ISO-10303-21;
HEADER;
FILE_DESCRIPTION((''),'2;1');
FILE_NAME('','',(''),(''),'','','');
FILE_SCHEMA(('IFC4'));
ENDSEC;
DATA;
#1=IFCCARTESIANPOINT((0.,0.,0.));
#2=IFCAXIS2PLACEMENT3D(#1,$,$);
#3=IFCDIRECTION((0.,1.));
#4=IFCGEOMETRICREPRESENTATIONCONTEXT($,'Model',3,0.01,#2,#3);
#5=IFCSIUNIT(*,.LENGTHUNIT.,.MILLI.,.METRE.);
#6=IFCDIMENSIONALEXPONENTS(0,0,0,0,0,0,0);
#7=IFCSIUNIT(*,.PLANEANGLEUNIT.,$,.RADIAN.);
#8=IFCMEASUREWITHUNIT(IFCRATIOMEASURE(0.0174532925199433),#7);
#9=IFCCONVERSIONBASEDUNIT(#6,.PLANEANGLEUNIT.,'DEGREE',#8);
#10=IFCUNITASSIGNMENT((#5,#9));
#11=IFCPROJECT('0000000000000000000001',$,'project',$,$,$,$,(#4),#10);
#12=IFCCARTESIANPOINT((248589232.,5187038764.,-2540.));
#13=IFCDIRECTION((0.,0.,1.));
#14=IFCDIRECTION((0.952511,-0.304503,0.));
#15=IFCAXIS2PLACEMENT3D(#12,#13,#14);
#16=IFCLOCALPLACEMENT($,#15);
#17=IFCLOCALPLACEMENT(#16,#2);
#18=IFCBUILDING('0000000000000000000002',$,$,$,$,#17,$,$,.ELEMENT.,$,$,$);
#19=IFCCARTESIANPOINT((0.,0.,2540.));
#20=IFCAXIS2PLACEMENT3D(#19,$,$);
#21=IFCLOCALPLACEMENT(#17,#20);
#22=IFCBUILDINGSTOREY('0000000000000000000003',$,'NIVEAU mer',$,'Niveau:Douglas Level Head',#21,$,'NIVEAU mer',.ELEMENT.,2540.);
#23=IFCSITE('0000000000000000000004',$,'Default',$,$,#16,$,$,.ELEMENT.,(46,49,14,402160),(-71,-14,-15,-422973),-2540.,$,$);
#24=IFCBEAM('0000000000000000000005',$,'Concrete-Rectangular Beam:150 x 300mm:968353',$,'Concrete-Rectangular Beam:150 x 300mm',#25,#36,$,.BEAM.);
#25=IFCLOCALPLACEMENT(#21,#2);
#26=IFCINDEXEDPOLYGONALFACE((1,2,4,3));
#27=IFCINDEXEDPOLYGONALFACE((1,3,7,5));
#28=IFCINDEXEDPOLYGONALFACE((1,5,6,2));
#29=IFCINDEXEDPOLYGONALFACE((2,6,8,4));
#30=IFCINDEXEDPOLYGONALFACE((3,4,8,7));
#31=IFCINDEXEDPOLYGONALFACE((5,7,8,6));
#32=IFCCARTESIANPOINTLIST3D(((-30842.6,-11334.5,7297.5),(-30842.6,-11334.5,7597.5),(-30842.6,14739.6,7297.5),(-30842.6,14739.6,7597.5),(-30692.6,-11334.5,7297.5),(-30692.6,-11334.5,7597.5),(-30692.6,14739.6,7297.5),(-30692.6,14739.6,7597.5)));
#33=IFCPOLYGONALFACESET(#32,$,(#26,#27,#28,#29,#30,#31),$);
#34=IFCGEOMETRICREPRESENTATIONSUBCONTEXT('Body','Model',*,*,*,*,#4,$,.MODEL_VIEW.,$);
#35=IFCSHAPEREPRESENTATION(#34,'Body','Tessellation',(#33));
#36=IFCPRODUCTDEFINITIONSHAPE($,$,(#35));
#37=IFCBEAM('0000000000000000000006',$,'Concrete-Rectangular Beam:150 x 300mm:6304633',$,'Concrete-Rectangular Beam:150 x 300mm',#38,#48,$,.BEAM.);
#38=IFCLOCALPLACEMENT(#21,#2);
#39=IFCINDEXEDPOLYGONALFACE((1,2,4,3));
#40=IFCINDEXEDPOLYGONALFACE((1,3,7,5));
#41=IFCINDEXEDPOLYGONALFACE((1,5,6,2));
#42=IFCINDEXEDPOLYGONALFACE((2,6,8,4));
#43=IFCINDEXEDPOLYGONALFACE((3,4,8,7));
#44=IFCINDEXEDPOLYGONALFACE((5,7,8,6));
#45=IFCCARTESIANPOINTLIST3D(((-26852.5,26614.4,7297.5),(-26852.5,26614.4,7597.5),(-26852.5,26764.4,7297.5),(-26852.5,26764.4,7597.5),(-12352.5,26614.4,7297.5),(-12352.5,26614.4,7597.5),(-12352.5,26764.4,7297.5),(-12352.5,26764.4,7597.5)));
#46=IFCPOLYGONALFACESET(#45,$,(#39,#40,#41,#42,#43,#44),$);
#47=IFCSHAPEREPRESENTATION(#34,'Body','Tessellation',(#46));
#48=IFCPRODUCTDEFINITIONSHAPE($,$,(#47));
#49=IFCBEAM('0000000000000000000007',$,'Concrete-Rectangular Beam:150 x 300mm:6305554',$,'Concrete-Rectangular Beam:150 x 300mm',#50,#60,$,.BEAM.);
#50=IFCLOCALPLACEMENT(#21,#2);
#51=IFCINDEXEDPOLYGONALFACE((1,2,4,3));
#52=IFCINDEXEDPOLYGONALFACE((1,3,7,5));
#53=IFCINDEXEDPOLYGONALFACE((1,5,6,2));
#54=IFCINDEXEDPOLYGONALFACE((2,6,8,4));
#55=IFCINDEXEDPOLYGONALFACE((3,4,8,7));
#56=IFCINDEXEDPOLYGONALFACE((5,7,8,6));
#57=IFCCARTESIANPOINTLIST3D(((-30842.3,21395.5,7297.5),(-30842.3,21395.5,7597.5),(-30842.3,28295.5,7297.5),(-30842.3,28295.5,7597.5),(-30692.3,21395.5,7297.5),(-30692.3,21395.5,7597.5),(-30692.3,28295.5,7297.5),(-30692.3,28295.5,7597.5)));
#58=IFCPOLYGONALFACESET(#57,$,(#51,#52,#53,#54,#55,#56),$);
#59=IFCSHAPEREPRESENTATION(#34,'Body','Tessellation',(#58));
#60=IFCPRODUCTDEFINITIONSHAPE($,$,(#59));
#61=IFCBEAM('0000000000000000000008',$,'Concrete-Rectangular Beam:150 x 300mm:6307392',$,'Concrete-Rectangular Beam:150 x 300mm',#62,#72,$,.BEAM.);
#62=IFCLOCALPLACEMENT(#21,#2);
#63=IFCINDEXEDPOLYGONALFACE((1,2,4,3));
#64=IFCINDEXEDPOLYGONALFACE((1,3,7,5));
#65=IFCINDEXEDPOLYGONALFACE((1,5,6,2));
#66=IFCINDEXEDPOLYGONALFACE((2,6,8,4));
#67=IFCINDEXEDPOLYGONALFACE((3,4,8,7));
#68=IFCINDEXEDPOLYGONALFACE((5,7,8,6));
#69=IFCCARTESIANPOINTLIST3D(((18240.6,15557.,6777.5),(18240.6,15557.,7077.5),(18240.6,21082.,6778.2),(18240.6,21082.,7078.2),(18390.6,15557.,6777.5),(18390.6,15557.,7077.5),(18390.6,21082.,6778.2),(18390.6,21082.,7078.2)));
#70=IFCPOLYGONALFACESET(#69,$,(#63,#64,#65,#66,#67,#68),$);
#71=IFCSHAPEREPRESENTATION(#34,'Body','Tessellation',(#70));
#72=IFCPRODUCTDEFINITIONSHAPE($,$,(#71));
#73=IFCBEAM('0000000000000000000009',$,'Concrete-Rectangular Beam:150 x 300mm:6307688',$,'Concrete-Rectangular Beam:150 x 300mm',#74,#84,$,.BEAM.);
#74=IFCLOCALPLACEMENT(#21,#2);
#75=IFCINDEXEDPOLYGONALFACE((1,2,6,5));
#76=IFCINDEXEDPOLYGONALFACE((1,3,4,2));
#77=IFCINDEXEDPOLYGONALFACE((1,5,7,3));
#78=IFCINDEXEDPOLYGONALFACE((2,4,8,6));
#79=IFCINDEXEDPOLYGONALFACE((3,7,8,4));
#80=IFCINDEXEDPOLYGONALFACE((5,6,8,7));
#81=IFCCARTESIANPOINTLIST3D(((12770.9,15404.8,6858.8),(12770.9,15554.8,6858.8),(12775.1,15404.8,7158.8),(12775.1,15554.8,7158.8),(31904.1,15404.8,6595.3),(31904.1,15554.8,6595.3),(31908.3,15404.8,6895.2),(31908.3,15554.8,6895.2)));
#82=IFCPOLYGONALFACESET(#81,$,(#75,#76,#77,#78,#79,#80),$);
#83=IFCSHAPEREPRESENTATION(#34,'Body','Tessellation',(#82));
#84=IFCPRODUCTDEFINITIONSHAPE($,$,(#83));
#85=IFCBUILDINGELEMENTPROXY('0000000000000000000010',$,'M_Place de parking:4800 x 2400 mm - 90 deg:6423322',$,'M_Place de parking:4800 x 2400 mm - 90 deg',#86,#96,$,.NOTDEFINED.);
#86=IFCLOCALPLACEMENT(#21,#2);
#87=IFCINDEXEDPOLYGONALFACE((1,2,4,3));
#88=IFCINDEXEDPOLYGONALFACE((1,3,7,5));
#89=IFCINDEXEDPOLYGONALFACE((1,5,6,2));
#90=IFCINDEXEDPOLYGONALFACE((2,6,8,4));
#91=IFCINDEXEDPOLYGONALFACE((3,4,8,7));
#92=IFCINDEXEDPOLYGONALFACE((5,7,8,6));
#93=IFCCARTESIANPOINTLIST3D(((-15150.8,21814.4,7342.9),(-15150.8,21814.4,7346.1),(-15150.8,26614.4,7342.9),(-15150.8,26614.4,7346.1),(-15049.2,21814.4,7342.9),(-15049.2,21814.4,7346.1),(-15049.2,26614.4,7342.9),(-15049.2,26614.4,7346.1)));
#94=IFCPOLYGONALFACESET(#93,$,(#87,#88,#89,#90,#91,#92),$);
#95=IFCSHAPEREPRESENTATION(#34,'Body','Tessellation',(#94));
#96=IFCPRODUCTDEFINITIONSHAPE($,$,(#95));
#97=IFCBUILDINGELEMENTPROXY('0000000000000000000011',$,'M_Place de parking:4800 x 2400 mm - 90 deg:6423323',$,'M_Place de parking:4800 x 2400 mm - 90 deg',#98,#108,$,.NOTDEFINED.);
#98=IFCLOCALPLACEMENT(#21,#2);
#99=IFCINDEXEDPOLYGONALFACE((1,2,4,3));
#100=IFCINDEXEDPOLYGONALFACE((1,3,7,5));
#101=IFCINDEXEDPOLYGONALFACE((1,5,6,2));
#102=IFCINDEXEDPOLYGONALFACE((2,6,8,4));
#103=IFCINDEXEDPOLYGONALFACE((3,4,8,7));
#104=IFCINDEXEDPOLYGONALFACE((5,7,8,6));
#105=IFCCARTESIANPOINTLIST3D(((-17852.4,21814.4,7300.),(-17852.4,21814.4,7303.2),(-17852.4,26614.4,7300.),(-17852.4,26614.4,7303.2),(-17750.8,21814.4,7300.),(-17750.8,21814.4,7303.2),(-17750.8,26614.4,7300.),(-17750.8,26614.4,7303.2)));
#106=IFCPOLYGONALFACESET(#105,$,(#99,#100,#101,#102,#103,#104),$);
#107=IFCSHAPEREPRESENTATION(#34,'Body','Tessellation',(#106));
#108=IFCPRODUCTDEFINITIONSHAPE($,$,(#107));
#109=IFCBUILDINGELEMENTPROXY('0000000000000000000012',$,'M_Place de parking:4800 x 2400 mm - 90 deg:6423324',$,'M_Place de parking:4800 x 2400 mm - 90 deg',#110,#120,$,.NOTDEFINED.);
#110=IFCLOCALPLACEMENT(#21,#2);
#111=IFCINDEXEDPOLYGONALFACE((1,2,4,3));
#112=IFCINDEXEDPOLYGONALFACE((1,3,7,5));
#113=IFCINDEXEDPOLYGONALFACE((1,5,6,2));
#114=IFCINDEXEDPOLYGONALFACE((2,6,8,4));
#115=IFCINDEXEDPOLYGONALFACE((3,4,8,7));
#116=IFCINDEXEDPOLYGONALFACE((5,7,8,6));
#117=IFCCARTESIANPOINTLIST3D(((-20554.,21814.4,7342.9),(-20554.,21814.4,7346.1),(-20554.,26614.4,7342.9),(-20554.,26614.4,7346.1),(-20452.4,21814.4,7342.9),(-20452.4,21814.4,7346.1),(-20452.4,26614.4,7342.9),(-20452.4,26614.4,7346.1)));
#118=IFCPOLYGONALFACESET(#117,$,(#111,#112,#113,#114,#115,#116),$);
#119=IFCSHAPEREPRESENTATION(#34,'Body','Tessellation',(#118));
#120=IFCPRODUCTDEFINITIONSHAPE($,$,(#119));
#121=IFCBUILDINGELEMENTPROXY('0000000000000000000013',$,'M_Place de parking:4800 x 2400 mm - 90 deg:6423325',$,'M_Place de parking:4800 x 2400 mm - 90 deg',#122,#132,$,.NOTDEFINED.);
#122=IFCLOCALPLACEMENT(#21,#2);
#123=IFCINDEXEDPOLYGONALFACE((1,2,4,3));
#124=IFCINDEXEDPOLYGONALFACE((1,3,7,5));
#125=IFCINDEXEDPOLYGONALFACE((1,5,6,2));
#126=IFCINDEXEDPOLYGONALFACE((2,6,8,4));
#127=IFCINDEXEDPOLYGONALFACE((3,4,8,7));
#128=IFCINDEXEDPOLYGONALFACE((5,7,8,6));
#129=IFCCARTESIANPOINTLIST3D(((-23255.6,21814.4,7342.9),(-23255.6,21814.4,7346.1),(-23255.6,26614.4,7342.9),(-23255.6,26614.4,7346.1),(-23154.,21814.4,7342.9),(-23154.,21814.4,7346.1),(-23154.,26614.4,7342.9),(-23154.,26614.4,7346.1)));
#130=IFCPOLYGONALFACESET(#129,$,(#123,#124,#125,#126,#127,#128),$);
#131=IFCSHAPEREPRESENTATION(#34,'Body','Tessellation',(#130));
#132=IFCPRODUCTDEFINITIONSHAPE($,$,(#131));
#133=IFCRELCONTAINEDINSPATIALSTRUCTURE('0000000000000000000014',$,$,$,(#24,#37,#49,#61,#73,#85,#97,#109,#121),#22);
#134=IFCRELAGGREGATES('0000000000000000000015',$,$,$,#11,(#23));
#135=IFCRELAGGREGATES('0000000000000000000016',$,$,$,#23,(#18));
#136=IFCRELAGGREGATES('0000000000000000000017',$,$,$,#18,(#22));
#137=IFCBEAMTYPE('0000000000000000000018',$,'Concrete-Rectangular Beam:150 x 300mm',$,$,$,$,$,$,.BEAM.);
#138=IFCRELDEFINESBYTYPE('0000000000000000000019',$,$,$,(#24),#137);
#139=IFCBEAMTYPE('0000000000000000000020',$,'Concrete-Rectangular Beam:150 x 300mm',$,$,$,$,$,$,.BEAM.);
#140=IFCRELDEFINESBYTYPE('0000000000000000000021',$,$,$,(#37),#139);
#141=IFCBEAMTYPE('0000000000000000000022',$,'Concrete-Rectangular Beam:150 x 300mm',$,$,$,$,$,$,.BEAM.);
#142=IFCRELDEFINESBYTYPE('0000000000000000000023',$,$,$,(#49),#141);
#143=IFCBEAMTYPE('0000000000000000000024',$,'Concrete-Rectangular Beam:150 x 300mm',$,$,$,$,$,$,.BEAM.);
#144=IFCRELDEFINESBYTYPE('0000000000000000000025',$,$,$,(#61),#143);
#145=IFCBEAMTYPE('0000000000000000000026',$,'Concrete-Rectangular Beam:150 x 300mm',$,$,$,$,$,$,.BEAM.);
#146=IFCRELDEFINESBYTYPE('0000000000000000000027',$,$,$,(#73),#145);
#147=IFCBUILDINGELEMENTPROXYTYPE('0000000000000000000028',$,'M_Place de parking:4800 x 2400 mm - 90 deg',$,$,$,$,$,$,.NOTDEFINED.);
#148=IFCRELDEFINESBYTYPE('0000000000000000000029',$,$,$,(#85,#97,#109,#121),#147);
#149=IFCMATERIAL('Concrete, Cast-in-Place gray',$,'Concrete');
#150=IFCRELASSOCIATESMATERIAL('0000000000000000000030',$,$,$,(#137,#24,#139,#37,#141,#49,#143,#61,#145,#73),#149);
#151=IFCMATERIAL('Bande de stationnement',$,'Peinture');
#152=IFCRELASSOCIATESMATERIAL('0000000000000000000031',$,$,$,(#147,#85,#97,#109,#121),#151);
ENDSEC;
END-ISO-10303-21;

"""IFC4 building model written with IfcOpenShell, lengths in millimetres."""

from ifc_helpers import new_model, entity, si_unit, converted_unit, direction, frame, origin, place, context, subcontext, project, spatial, indexed_curve, outline, extrude, source, transform, mapped, material, type_object, type_shapes, element, save


model = new_model("IFC4")

# Units and contexts
model_context = context("Model", 3, precision=0.01, world=origin(), true_north=direction((0.0, 1.0)))
body_context = subcontext(model_context, "Body", "Model", "MODEL_VIEW")
ifc_project = project(units=[si_unit("LENGTHUNIT", "METRE", prefix="MILLI"), converted_unit("PLANEANGLEUNIT", "DEGREE", entity("IfcRatioMeasure", 0.0174532925199433), si_unit("PLANEANGLEUNIT", "RADIAN"), dimensions=[0, 0, 0, 0, 0, 0, 0])], contexts=[model_context])

# Site, building, storey
site_placement = place(None, frame((248589232.0, 5187038764.0, -2540.0), z_axis=(0.0, 0.0, 1.0), x_axis=(0.952511, -0.304503, 0.0)))
site = spatial("IfcSite", under=ifc_project, at=site_placement, Name="Default", CompositionType="ELEMENT", RefLatitude=(46, 49, 14, 402160), RefLongitude=(-71, -14, -15, -422973), RefElevation=-2540.0)
building_placement = place(site_placement, origin())
building = spatial("IfcBuilding", under=site, at=building_placement, CompositionType="ELEMENT")
storey_placement = place(building_placement, frame((0.0, 0.0, 2540.0)))
storey = spatial("IfcBuildingStorey", under=building, at=storey_placement, Name="NIVEAU mer", ObjectType="Niveau:Douglas Level Head", LongName="NIVEAU mer", CompositionType="ELEMENT", Elevation=2540.0)

# Beams
ifc_material_1 = material(Name="Concrete, Cast-in-Place gray", Category="Concrete")
beam_type_1 = type_object("IfcBeamType", Name="Concrete-Rectangular Beam:150 x 300mm", PredefinedType="BEAM", material=ifc_material_1)
shared_shape_1 = source(origin(), body_context, "Body", "SweptSolid", [
    extrude(outline(indexed_curve([(-13037.1, -150.0), (13037.1, -150.0), (13037.1, 150.0), (-13037.1, 150.0), (-13037.1, -150.0)], self_intersect=False)), frame((-30842.6, 1702.5, 9987.5), z_axis=(1.0, 0.0, 0.0), x_axis=(0.0, 1.0, 0.0)), (0.0, 0.0, 1.0), 150.0),
])
type_shapes(beam_type_1, [shared_shape_1])
beam_1_placement = place(storey_placement, frame((0.0, 0.0, -2540.0)))
element("IfcBeam", 1, at=beam_1_placement, inside=storey, type_object=beam_type_1, material=ifc_material_1, Name="Concrete-Rectangular Beam:150 x 300mm:968353", ObjectType="Concrete-Rectangular Beam:150 x 300mm", PredefinedType="BEAM", context=body_context, shape_type="MappedRepresentation", body=[
    mapped(shared_shape_1, transform((0.0, 0.0, 0.0), scale=1.0)),
])
beam_type_2 = type_object("IfcBeamType", Name="Concrete-Rectangular Beam:150 x 300mm", PredefinedType="BEAM", material=ifc_material_1)
shared_shape_2 = source(origin(), body_context, "Body", "SweptSolid", [
    extrude(outline(indexed_curve([(-150.0, -75.0), (150.0, -75.0), (150.0, 75.0), (-150.0, 75.0), (-150.0, -75.0)], self_intersect=False)), frame((-26852.5, 26689.4, 9987.5), z_axis=(1.0, 0.0, 0.0), x_axis=(0.0, 0.0, -1.0)), (0.0, 0.0, 1.0), 14500.0),
])
type_shapes(beam_type_2, [shared_shape_2])
beam_2_placement = place(storey_placement, frame((0.0, 0.0, -2540.0)))
element("IfcBeam", 2, at=beam_2_placement, inside=storey, type_object=beam_type_2, material=ifc_material_1, Name="Concrete-Rectangular Beam:150 x 300mm:6304633", ObjectType="Concrete-Rectangular Beam:150 x 300mm", PredefinedType="BEAM", context=body_context, shape_type="MappedRepresentation", body=[
    mapped(shared_shape_2, transform((0.0, 0.0, 0.0), scale=1.0)),
])
beam_type_3 = type_object("IfcBeamType", Name="Concrete-Rectangular Beam:150 x 300mm", PredefinedType="BEAM", material=ifc_material_1)
shared_shape_3 = source(origin(), body_context, "Body", "SweptSolid", [
    extrude(outline(indexed_curve([(-3450.0, -150.0), (3450.0, -150.0), (3450.0, 150.0), (-3450.0, 150.0), (-3450.0, -150.0)], self_intersect=False)), frame((-30842.3, 24845.5, 9987.5), z_axis=(1.0, 0.0, 0.0), x_axis=(0.0, -1.0, 0.0)), (0.0, 0.0, 1.0), 150.0),
])
type_shapes(beam_type_3, [shared_shape_3])
beam_3_placement = place(storey_placement, frame((0.0, 0.0, -2540.0)))
element("IfcBeam", 3, at=beam_3_placement, inside=storey, type_object=beam_type_3, material=ifc_material_1, Name="Concrete-Rectangular Beam:150 x 300mm:6305554", ObjectType="Concrete-Rectangular Beam:150 x 300mm", PredefinedType="BEAM", context=body_context, shape_type="MappedRepresentation", body=[
    mapped(shared_shape_3, transform((0.0, 0.0, 0.0), scale=1.0)),
])
beam_type_4 = type_object("IfcBeamType", Name="Concrete-Rectangular Beam:150 x 300mm", PredefinedType="BEAM", material=ifc_material_1)
shared_shape_4 = source(origin(), body_context, "Body", "SweptSolid", [
    extrude(outline(indexed_curve([(-2762.5, -150.0), (2762.5, -150.0), (2762.5, 150.0), (-2762.5, 150.0), (-2762.5, -150.0)], self_intersect=False)), frame((18240.6, 18319.5, 9467.9), z_axis=(1.0, 0.0, 0.0), x_axis=(0.0, -1.0, -0.000122)), (0.0, 0.0, 1.0), 150.0),
])
type_shapes(beam_type_4, [shared_shape_4])
beam_4_placement = place(storey_placement, frame((0.0, 0.0, -2540.0)))
element("IfcBeam", 4, at=beam_4_placement, inside=storey, type_object=beam_type_4, material=ifc_material_1, Name="Concrete-Rectangular Beam:150 x 300mm:6307392", ObjectType="Concrete-Rectangular Beam:150 x 300mm", PredefinedType="BEAM", context=body_context, shape_type="MappedRepresentation", body=[
    mapped(shared_shape_4, transform((0.0, 0.0, 0.0), scale=1.0)),
])
beam_type_5 = type_object("IfcBeamType", Name="Concrete-Rectangular Beam:150 x 300mm", PredefinedType="BEAM", material=ifc_material_1)
shared_shape_5 = source(origin(), body_context, "Body", "SweptSolid", [
    extrude(outline(indexed_curve([(-150.0, -75.0), (150.0, -75.0), (150.0, 75.0), (-150.0, 75.0), (-150.0, -75.0)], self_intersect=False)), frame((12773.0, 15479.8, 9548.8), z_axis=(0.999905, 0.0, -0.013773), x_axis=(-0.013773, 0.0, -0.999905)), (0.0, 0.0, 1.0), 19135.0),
])
type_shapes(beam_type_5, [shared_shape_5])
beam_5_placement = place(storey_placement, frame((0.0, 0.0, -2540.0)))
element("IfcBeam", 5, at=beam_5_placement, inside=storey, type_object=beam_type_5, material=ifc_material_1, Name="Concrete-Rectangular Beam:150 x 300mm:6307688", ObjectType="Concrete-Rectangular Beam:150 x 300mm", PredefinedType="BEAM", context=body_context, shape_type="MappedRepresentation", body=[
    mapped(shared_shape_5, transform((0.0, 0.0, 0.0), scale=1.0)),
])

# Building element proxies
ifc_material_2 = material(Name="Bande de stationnement", Category="Peinture")
building_element_proxy_type = type_object("IfcBuildingElementProxyType", Name="M_Place de parking:4800 x 2400 mm - 90 deg", PredefinedType="NOTDEFINED", material=ifc_material_2)
shared_shape_6 = source(origin(), body_context, "Body", "SweptSolid", [
    extrude(outline(indexed_curve([(-2400.0, -50.8), (2400.0, -50.8), (2400.0, 50.8), (-2400.0, 50.8), (-2400.0, -50.8)], self_intersect=False)), frame((1300.0, -4800.0, 0.0), z_axis=(0.0, 0.0, 1.0), x_axis=(0.0, -1.0, 0.0)), (0.0, 0.0, 1.0), 3.2),
])
type_shapes(building_element_proxy_type, [shared_shape_6])
for number, where, name in (
    (6, (-16400.0, 29014.4, 7342.9), "M_Place de parking:4800 x 2400 mm - 90 deg:6423322"),
    (7, (-19101.6, 29014.4, 7300.0), "M_Place de parking:4800 x 2400 mm - 90 deg:6423323"),
    (8, (-21803.2, 29014.4, 7342.9), "M_Place de parking:4800 x 2400 mm - 90 deg:6423324"),
    (9, (-24504.8, 29014.4, 7342.9), "M_Place de parking:4800 x 2400 mm - 90 deg:6423325"),
):
    element("IfcBuildingElementProxy", number, at=place(storey_placement, frame(where)), inside=storey, type_object=building_element_proxy_type, material=ifc_material_2, Name=name, ObjectType="M_Place de parking:4800 x 2400 mm - 90 deg", PredefinedType="NOTDEFINED", context=body_context, shape_type="MappedRepresentation", body=[
        mapped(shared_shape_6, transform((0.0, 0.0, 0.0), scale=1.0)),
    ])

save(model, "model.ifc")
